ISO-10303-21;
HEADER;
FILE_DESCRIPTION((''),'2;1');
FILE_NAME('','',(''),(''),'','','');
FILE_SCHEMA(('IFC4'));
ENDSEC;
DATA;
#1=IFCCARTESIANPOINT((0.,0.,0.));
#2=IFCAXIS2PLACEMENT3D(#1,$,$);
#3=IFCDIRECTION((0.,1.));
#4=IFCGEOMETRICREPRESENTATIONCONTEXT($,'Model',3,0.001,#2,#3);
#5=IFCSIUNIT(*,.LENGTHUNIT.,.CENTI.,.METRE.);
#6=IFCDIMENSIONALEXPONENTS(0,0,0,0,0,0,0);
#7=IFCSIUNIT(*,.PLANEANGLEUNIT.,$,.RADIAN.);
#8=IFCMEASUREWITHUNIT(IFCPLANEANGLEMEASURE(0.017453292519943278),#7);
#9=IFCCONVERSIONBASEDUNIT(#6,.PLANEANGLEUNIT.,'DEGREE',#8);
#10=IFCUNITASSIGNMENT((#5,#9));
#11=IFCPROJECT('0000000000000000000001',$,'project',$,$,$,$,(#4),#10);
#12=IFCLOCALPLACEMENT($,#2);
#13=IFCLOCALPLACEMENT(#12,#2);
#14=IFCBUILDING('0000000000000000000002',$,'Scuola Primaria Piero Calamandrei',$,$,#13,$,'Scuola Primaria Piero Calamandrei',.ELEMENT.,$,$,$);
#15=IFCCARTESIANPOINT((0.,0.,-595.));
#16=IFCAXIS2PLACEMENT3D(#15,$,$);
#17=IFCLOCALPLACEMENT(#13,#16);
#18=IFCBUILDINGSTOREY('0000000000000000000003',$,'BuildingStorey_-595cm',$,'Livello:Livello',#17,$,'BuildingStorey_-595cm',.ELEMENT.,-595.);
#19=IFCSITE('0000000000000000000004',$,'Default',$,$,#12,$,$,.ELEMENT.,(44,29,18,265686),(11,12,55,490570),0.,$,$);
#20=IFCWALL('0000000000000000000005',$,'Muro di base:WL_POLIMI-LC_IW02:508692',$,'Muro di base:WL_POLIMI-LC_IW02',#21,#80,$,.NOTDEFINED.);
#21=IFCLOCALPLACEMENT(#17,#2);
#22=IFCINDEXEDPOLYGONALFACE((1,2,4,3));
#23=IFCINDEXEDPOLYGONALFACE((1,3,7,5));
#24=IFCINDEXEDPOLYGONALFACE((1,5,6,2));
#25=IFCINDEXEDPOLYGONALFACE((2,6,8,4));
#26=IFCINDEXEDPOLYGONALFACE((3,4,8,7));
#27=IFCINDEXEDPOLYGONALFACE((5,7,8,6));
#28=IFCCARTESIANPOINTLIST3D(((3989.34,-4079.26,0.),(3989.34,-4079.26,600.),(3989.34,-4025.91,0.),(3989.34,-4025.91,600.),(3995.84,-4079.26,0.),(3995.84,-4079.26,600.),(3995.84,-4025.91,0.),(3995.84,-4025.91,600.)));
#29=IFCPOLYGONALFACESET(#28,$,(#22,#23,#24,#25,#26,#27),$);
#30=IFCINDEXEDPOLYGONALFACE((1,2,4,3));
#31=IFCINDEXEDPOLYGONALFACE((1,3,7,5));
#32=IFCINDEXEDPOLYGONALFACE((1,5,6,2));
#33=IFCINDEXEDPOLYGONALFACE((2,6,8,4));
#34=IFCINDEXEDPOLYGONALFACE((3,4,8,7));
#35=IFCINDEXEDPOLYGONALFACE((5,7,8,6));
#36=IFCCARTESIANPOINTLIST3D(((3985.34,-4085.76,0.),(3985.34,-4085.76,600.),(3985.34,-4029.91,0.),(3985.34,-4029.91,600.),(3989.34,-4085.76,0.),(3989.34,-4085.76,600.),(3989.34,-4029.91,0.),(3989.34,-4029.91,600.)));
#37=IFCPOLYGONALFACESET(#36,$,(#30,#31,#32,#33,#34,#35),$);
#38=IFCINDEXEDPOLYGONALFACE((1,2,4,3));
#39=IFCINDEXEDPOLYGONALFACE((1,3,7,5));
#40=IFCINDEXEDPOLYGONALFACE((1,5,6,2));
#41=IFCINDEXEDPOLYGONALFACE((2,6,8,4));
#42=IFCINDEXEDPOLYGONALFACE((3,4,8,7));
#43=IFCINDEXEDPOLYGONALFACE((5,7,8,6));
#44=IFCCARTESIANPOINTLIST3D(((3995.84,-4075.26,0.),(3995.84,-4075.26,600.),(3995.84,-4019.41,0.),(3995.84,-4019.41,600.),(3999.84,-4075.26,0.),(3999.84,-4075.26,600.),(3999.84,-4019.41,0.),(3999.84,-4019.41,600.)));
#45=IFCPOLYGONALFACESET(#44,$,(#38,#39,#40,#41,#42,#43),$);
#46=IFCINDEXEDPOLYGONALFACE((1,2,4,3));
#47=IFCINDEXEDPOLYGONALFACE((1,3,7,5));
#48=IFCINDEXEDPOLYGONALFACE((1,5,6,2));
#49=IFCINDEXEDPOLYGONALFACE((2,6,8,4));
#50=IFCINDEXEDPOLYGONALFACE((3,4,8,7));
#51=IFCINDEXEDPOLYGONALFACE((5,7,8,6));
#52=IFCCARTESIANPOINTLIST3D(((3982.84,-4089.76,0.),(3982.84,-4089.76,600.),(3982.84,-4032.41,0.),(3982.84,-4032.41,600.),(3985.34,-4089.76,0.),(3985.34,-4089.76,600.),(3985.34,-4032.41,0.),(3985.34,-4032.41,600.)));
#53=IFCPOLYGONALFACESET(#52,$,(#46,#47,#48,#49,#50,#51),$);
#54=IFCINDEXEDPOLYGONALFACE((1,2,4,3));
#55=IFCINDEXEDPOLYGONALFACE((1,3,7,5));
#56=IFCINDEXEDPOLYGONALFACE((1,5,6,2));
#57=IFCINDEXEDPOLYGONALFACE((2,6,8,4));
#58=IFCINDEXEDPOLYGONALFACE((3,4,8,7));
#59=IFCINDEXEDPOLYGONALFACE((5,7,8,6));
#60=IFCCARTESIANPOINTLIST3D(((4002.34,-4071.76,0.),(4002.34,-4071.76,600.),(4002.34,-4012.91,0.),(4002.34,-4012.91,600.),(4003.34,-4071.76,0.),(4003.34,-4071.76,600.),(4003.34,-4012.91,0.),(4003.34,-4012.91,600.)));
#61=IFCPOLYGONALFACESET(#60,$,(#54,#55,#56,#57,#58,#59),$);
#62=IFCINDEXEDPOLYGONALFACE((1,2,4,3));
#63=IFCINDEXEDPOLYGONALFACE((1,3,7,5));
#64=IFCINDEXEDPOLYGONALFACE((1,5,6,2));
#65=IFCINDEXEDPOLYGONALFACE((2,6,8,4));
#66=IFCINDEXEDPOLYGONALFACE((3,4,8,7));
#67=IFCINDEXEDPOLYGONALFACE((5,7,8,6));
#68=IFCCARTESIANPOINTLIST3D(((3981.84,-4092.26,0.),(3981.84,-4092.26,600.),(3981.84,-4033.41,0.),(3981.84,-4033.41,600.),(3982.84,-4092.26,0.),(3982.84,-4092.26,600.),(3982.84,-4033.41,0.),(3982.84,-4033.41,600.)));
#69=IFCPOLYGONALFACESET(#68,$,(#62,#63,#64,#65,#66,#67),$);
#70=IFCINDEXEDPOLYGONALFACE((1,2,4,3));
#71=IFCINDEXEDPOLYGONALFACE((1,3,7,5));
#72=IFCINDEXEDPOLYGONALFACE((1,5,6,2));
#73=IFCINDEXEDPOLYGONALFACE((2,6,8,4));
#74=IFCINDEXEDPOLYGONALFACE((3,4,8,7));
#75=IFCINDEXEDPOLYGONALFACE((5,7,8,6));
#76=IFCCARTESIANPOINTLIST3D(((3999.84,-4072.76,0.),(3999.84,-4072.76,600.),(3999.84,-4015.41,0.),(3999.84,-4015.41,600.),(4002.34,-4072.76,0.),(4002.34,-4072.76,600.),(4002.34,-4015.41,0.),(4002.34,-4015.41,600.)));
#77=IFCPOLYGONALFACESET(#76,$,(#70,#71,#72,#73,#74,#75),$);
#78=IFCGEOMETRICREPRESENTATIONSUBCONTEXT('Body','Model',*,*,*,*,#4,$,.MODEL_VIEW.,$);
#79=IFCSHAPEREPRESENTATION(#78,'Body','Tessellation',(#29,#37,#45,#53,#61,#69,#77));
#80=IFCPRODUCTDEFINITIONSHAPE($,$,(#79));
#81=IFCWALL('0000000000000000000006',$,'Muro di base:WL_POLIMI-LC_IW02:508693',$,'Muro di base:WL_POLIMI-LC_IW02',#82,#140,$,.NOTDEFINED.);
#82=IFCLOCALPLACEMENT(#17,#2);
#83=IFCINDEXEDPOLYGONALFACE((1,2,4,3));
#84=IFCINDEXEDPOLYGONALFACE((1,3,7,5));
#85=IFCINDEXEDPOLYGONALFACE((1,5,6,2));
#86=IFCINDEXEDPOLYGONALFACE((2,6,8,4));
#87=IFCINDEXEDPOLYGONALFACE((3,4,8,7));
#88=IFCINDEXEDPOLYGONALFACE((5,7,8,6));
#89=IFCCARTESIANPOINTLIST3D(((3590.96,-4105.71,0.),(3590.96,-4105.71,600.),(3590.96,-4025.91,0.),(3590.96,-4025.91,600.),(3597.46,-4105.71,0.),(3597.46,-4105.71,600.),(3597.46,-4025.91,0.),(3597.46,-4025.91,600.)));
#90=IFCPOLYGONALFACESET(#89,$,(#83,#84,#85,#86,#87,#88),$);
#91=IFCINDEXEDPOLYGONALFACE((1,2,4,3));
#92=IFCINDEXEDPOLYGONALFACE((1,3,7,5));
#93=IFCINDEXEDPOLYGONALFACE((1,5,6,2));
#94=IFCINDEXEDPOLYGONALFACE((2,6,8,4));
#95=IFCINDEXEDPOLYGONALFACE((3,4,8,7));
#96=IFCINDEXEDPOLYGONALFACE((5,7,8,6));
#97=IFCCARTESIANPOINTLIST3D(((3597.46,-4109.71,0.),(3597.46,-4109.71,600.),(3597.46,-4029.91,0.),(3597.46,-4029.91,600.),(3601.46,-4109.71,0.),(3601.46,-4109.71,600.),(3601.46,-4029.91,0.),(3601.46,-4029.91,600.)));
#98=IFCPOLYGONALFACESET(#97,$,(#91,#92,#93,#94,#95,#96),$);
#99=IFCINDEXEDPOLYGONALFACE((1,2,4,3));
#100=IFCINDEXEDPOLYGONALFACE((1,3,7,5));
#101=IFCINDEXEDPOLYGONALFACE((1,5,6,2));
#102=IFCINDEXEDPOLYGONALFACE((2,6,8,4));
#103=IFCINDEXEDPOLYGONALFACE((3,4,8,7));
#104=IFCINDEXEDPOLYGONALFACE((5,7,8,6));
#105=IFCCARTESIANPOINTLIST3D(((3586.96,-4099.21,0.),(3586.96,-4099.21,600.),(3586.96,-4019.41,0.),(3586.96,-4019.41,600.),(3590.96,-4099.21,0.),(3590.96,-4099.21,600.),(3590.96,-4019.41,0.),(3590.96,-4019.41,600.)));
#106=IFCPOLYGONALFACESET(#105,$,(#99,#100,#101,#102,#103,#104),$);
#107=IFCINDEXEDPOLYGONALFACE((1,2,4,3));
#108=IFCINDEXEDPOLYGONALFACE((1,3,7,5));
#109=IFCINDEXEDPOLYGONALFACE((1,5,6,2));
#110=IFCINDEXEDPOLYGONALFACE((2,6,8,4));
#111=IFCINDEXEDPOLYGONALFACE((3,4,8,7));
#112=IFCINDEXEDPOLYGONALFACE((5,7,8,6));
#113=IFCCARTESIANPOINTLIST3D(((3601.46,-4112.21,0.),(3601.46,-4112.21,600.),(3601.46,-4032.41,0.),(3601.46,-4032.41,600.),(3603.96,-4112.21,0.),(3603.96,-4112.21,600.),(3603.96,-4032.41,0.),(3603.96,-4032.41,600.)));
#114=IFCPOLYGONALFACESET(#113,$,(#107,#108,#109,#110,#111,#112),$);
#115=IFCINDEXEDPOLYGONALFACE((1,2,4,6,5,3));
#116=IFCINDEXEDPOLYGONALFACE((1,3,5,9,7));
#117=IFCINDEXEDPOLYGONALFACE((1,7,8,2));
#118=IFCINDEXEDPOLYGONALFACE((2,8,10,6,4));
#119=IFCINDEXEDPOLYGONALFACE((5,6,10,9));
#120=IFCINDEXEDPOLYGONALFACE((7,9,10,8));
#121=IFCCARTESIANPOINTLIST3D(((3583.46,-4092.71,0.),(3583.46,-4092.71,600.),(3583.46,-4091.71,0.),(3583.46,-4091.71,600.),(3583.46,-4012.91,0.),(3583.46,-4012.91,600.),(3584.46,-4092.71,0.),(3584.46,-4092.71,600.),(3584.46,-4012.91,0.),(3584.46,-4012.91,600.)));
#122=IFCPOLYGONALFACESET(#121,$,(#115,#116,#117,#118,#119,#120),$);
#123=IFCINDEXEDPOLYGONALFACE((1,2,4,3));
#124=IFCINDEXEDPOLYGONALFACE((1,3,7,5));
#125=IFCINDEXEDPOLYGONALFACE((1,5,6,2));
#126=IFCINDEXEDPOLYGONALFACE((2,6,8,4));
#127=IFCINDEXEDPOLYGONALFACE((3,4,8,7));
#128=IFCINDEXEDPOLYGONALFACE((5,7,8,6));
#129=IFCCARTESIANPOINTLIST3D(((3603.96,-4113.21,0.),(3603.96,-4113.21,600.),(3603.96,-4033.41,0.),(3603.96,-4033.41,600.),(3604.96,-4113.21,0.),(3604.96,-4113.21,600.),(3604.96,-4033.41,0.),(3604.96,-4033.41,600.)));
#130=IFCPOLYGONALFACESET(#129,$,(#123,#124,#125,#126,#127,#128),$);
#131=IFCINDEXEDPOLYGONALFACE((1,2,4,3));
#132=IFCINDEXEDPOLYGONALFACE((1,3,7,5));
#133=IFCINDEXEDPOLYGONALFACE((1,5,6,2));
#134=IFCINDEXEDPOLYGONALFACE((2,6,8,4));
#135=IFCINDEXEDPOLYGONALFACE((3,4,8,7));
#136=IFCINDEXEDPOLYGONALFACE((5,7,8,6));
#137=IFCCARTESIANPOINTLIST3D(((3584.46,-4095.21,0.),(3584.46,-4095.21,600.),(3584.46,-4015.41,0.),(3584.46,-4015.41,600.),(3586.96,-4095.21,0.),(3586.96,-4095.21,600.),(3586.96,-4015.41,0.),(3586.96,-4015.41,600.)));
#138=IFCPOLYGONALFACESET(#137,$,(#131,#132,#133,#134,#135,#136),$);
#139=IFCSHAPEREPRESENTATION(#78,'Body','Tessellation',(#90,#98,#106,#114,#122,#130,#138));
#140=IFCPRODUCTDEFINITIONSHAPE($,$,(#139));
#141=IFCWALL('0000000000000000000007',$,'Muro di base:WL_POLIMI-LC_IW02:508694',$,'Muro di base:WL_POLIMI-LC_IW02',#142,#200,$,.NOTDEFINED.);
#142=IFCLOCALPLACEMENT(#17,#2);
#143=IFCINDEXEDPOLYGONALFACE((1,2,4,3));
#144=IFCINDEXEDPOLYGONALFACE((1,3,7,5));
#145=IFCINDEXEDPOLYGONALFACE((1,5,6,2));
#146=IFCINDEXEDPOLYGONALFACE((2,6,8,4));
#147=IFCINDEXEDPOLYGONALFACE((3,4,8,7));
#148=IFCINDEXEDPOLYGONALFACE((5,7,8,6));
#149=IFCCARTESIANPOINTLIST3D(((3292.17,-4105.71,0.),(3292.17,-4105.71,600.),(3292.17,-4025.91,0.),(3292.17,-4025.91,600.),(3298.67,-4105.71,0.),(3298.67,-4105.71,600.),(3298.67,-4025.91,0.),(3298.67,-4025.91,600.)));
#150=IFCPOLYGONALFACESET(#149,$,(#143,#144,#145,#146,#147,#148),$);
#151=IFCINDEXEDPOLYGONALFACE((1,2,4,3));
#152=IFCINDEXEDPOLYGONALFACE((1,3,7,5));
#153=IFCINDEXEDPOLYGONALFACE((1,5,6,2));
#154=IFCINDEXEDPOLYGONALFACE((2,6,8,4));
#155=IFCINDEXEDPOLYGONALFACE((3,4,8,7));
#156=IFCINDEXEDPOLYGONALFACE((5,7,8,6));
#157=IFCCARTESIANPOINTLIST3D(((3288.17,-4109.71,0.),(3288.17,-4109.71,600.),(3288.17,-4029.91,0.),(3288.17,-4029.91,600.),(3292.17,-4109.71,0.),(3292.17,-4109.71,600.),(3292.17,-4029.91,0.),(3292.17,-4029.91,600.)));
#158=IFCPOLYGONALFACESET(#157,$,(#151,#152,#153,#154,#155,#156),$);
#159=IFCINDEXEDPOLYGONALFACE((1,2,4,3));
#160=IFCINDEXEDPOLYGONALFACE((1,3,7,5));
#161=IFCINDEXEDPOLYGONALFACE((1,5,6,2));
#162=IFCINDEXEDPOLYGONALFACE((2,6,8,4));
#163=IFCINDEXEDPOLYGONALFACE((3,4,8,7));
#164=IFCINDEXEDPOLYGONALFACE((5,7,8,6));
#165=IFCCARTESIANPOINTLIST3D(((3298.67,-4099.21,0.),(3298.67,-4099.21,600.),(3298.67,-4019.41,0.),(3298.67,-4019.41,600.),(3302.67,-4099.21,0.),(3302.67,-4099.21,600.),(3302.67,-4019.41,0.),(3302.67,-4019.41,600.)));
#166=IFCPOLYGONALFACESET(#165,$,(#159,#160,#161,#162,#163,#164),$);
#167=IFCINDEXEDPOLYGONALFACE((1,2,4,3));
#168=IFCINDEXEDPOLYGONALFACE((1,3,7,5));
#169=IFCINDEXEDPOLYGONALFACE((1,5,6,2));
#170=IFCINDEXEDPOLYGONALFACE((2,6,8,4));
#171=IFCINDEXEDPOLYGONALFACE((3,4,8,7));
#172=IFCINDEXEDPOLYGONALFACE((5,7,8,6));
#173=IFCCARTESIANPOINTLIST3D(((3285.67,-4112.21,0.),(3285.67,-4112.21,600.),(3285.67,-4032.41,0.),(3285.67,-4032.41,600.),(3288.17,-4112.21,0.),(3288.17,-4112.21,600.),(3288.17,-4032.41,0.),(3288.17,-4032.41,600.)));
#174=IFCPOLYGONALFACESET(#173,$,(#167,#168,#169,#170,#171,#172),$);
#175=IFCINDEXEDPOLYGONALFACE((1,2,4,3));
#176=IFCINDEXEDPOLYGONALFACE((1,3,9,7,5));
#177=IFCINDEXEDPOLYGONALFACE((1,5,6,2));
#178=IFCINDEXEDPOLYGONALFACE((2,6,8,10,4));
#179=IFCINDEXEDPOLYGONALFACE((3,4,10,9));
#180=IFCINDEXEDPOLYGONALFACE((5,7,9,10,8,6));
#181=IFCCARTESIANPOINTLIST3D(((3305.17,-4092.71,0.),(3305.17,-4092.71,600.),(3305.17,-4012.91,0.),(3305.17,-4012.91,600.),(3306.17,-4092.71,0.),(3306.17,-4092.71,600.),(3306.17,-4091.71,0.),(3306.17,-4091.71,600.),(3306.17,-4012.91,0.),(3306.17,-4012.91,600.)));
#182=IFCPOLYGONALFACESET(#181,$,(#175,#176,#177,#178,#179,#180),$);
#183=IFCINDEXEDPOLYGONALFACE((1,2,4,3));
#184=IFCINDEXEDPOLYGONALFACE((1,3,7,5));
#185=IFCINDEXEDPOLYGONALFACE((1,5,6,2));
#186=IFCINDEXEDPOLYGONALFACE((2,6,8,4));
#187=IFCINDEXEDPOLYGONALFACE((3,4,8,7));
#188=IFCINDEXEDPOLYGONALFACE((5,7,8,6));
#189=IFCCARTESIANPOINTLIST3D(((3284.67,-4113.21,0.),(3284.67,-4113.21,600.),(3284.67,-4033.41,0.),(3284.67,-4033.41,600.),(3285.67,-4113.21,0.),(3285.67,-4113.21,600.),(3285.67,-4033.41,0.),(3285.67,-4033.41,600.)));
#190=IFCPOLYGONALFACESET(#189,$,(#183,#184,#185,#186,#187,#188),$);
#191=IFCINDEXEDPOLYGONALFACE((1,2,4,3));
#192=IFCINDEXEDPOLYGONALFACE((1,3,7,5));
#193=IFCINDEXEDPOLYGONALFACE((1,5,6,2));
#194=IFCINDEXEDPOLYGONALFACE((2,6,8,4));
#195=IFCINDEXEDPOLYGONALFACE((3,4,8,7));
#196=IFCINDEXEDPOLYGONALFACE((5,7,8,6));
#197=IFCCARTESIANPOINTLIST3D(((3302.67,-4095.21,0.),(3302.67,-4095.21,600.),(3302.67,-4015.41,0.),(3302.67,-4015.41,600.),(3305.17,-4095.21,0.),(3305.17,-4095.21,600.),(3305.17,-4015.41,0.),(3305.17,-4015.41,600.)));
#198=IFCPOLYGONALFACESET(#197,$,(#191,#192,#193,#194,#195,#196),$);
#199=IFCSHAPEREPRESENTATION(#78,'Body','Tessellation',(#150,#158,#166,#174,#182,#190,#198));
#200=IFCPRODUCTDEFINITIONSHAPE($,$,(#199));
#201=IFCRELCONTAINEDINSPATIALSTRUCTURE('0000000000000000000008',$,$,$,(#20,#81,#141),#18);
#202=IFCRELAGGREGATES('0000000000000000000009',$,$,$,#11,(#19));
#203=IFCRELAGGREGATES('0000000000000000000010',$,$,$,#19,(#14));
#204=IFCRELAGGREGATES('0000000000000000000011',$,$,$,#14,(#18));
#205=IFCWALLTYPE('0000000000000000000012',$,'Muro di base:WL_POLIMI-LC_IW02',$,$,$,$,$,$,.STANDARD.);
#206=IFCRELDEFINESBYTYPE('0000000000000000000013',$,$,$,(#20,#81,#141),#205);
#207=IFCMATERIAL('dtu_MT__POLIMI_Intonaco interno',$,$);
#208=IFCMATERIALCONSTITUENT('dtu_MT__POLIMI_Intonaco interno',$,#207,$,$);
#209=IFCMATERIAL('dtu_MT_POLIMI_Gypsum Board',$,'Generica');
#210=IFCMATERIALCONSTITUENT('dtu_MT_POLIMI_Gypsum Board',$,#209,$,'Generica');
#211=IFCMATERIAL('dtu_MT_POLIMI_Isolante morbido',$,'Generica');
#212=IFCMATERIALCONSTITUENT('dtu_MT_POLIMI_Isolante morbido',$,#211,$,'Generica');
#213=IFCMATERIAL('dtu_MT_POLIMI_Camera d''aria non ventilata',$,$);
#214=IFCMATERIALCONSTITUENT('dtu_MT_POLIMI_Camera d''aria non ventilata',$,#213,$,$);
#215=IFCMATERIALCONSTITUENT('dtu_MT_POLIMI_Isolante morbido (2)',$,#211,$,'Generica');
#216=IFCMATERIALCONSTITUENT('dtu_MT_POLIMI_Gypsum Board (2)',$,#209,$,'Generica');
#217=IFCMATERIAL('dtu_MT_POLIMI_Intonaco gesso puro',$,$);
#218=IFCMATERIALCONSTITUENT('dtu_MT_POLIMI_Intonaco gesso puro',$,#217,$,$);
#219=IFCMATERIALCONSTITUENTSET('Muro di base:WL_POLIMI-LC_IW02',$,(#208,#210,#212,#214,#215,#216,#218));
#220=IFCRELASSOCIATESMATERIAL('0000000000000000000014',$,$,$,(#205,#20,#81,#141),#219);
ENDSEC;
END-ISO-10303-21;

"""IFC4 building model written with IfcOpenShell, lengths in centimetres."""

from ifc_helpers import new_model, entity, si_unit, converted_unit, direction, frame, origin, place, context, subcontext, project, spatial, indexed_curve, outline, extrude, material, constituent, constituent_set, type_object, element, save


model = new_model("IFC4")

# Units and contexts
model_context = context("Model", 3, precision=0.001, world=origin(), true_north=direction((0.0, 1.0)))
body_context = subcontext(model_context, "Body", "Model", "MODEL_VIEW")
ifc_project = project(units=[si_unit("LENGTHUNIT", "METRE", prefix="CENTI"), converted_unit("PLANEANGLEUNIT", "DEGREE", entity("IfcPlaneAngleMeasure", 0.017453292519943278), si_unit("PLANEANGLEUNIT", "RADIAN"), dimensions=[0, 0, 0, 0, 0, 0, 0])], contexts=[model_context])

# Site, building, storey
site_placement = place(None, origin())
site = spatial("IfcSite", under=ifc_project, at=site_placement, Name="Default", CompositionType="ELEMENT", RefLatitude=(44, 29, 18, 265686), RefLongitude=(11, 12, 55, 490570), RefElevation=0.0)
building_placement = place(site_placement, origin())
building = spatial("IfcBuilding", under=site, at=building_placement, Name="Scuola Primaria Piero Calamandrei", LongName="Scuola Primaria Piero Calamandrei", CompositionType="ELEMENT")
storey_placement = place(building_placement, frame((0.0, 0.0, -595.0)))
storey = spatial("IfcBuildingStorey", under=building, at=storey_placement, Name="BuildingStorey_-595cm", ObjectType="Livello:Livello", LongName="BuildingStorey_-595cm", CompositionType="ELEMENT", Elevation=-595.0)

# Shared definitions
ifc_material_1 = material(Name="dtu_MT__POLIMI_Intonaco interno")
ifc_constituent_1 = constituent(ifc_material_1, Name="dtu_MT__POLIMI_Intonaco interno")
ifc_material_2 = material(Name="dtu_MT_POLIMI_Gypsum Board", Category="Generica")
ifc_constituent_2 = constituent(ifc_material_2, Name="dtu_MT_POLIMI_Gypsum Board", Category="Generica")
ifc_material_3 = material(Name="dtu_MT_POLIMI_Isolante morbido", Category="Generica")
ifc_constituent_3 = constituent(ifc_material_3, Name="dtu_MT_POLIMI_Isolante morbido", Category="Generica")
ifc_material_4 = material(Name="dtu_MT_POLIMI_Camera d'aria non ventilata")
ifc_constituent_4 = constituent(ifc_material_4, Name="dtu_MT_POLIMI_Camera d'aria non ventilata")
ifc_constituent_5 = constituent(ifc_material_3, Name="dtu_MT_POLIMI_Isolante morbido (2)", Category="Generica")
ifc_constituent_6 = constituent(ifc_material_2, Name="dtu_MT_POLIMI_Gypsum Board (2)", Category="Generica")
ifc_material_5 = material(Name="dtu_MT_POLIMI_Intonaco gesso puro")
ifc_constituent_7 = constituent(ifc_material_5, Name="dtu_MT_POLIMI_Intonaco gesso puro")
ifc_constituent_set_1 = constituent_set(constituents=[ifc_constituent_1, ifc_constituent_2, ifc_constituent_3, ifc_constituent_4, ifc_constituent_5, ifc_constituent_6, ifc_constituent_7], Name="Muro di base:WL_POLIMI-LC_IW02")
wall_type_1 = type_object("IfcWallType", Name="Muro di base:WL_POLIMI-LC_IW02", PredefinedType="STANDARD", material=ifc_constituent_set_1)

# Walls
wall_1_placement = place(storey_placement, frame((3992.59, -4071.76, 0.0), z_axis=(0.0, 0.0, 1.0), x_axis=(0.0, 1.0, 0.0)))
element("IfcWall", 1, at=wall_1_placement, inside=storey, type_object=wall_type_1, material=ifc_constituent_set_1, Name="Muro di base:WL_POLIMI-LC_IW02:508692", ObjectType="Muro di base:WL_POLIMI-LC_IW02", PredefinedType="NOTDEFINED", context=body_context, shape_type="SweptSolid", body=[
    extrude(outline(indexed_curve([(-26.68, -3.25), (26.68, -3.25), (26.68, 3.25), (-26.68, 3.25), (-26.68, -3.25)], self_intersect=False)), frame((19.18, 0.0, 0.0)), (0.0, 0.0, 1.0), 600.0),
    extrude(outline(indexed_curve([(-27.93, -2.0), (27.93, -2.0), (27.93, 2.0), (-27.93, 2.0), (-27.93, -2.0)], self_intersect=False)), frame((13.93, 5.25, 0.0)), (0.0, 0.0, 1.0), 600.0),
    extrude(outline(indexed_curve([(-27.93, -2.0), (27.93, -2.0), (27.93, 2.0), (-27.93, 2.0), (-27.93, -2.0)], self_intersect=False)), frame((24.43, -5.25, 0.0)), (0.0, 0.0, 1.0), 600.0),
    extrude(outline(indexed_curve([(-28.68, -1.25), (28.68, -1.25), (28.68, 1.25), (-28.68, 1.25), (-28.68, -1.25)], self_intersect=False)), frame((10.68, 8.5, 0.0)), (0.0, 0.0, 1.0), 600.0),
    extrude(outline(indexed_curve([(-0.5, -29.43), (0.5, -29.43), (0.5, 29.43), (-0.5, 29.43), (-0.5, -29.43)], self_intersect=False)), frame((29.43, -10.25, 0.0), z_axis=(0.0, 0.0, 1.0), x_axis=(0.0, 1.0, 0.0)), (0.0, 0.0, 1.0), 600.0),
    extrude(outline(indexed_curve([(-0.5, -29.43), (0.5, -29.43), (0.5, 29.43), (-0.5, 29.43), (-0.5, -29.43)], self_intersect=False)), frame((8.93, 10.25, 0.0), z_axis=(0.0, 0.0, 1.0), x_axis=(0.0, -1.0, 0.0)), (0.0, 0.0, 1.0), 600.0),
    extrude(outline(indexed_curve([(-28.68, -1.25), (28.68, -1.25), (28.68, 1.25), (-28.68, 1.25), (-28.68, -1.25)], self_intersect=False)), frame((27.68, -8.5, 0.0)), (0.0, 0.0, 1.0), 600.0),
])
wall_2_placement = place(storey_placement, frame((3594.21, -4033.41, 0.0), z_axis=(0.0, 0.0, 1.0), x_axis=(0.0, -1.0, 0.0)))
element("IfcWall", 2, at=wall_2_placement, inside=storey, type_object=wall_type_1, material=ifc_constituent_set_1, Name="Muro di base:WL_POLIMI-LC_IW02:508693", ObjectType="Muro di base:WL_POLIMI-LC_IW02", PredefinedType="NOTDEFINED", context=body_context, shape_type="SweptSolid", body=[
    extrude(outline(indexed_curve([(-39.9, -3.25), (39.9, -3.25), (39.9, 3.25), (-39.9, 3.25), (-39.9, -3.25)], self_intersect=False)), frame((32.4, 0.0, 0.0)), (0.0, 0.0, 1.0), 600.0),
    extrude(outline(indexed_curve([(-39.9, -2.0), (39.9, -2.0), (39.9, 2.0), (-39.9, 2.0), (-39.9, -2.0)], self_intersect=False)), frame((36.4, 5.25, 0.0)), (0.0, 0.0, 1.0), 600.0),
    extrude(outline(indexed_curve([(-39.9, -2.0), (39.9, -2.0), (39.9, 2.0), (-39.9, 2.0), (-39.9, -2.0)], self_intersect=False)), frame((25.9, -5.25, 0.0)), (0.0, 0.0, 1.0), 600.0),
    extrude(outline(indexed_curve([(-39.9, -1.25), (39.9, -1.25), (39.9, 1.25), (-39.9, 1.25), (-39.9, -1.25)], self_intersect=False)), frame((38.9, 8.5, 0.0)), (0.0, 0.0, 1.0), 600.0),
    extrude(outline(indexed_curve([(31.12, -0.4), (32.12, -0.4), (32.12, 0.6), (-47.68, 0.6), (-47.68, -0.4), (31.12, -0.4)], self_intersect=False)), frame((27.18, -10.35, 0.0)), (0.0, 0.0, 1.0), 600.0),
    extrude(outline(indexed_curve([(-0.5, -39.9), (0.5, -39.9), (0.5, 39.9), (-0.5, 39.9), (-0.5, -39.9)], self_intersect=False)), frame((39.9, 10.25, 0.0), z_axis=(0.0, 0.0, 1.0), x_axis=(0.0, -1.0, 0.0)), (0.0, 0.0, 1.0), 600.0),
    extrude(outline(indexed_curve([(-39.9, -1.25), (39.9, -1.25), (39.9, 1.25), (-39.9, 1.25), (-39.9, -1.25)], self_intersect=False)), frame((21.9, -8.5, 0.0)), (0.0, 0.0, 1.0), 600.0),
])
wall_3_placement = place(storey_placement, frame((3295.42, -4113.21, 0.0), z_axis=(0.0, 0.0, 1.0), x_axis=(0.0, 1.0, 0.0)))
element("IfcWall", 3, at=wall_3_placement, inside=storey, type_object=wall_type_1, material=ifc_constituent_set_1, Name="Muro di base:WL_POLIMI-LC_IW02:508694", ObjectType="Muro di base:WL_POLIMI-LC_IW02", PredefinedType="NOTDEFINED", context=body_context, shape_type="SweptSolid", body=[
    extrude(outline(indexed_curve([(-39.9, -3.25), (39.9, -3.25), (39.9, 3.25), (-39.9, 3.25), (-39.9, -3.25)], self_intersect=False)), frame((47.4, 0.0, 0.0)), (0.0, 0.0, 1.0), 600.0),
    extrude(outline(indexed_curve([(-39.9, -2.0), (39.9, -2.0), (39.9, 2.0), (-39.9, 2.0), (-39.9, -2.0)], self_intersect=False)), frame((43.4, 5.25, 0.0)), (0.0, 0.0, 1.0), 600.0),
    extrude(outline(indexed_curve([(-39.9, -2.0), (39.9, -2.0), (39.9, 2.0), (-39.9, 2.0), (-39.9, -2.0)], self_intersect=False)), frame((53.9, -5.25, 0.0)), (0.0, 0.0, 1.0), 600.0),
    extrude(outline(indexed_curve([(-39.9, -1.25), (39.9, -1.25), (39.9, 1.25), (-39.9, 1.25), (-39.9, -1.25)], self_intersect=False)), frame((40.9, 8.5, 0.0)), (0.0, 0.0, 1.0), 600.0),
    extrude(outline(indexed_curve([(-31.12, -0.4), (47.68, -0.4), (47.68, 0.6), (-32.12, 0.6), (-32.12, -0.4), (-31.12, -0.4)], self_intersect=False)), frame((52.62, -10.35, 0.0)), (0.0, 0.0, 1.0), 600.0),
    extrude(outline(indexed_curve([(-0.5, -39.9), (0.5, -39.9), (0.5, 39.9), (-0.5, 39.9), (-0.5, -39.9)], self_intersect=False)), frame((39.9, 10.25, 0.0), z_axis=(0.0, 0.0, 1.0), x_axis=(0.0, -1.0, 0.0)), (0.0, 0.0, 1.0), 600.0),
    extrude(outline(indexed_curve([(-39.9, -1.25), (39.9, -1.25), (39.9, 1.25), (-39.9, 1.25), (-39.9, -1.25)], self_intersect=False)), frame((57.9, -8.5, 0.0)), (0.0, 0.0, 1.0), 600.0),
])

save(model, "model.ifc")
